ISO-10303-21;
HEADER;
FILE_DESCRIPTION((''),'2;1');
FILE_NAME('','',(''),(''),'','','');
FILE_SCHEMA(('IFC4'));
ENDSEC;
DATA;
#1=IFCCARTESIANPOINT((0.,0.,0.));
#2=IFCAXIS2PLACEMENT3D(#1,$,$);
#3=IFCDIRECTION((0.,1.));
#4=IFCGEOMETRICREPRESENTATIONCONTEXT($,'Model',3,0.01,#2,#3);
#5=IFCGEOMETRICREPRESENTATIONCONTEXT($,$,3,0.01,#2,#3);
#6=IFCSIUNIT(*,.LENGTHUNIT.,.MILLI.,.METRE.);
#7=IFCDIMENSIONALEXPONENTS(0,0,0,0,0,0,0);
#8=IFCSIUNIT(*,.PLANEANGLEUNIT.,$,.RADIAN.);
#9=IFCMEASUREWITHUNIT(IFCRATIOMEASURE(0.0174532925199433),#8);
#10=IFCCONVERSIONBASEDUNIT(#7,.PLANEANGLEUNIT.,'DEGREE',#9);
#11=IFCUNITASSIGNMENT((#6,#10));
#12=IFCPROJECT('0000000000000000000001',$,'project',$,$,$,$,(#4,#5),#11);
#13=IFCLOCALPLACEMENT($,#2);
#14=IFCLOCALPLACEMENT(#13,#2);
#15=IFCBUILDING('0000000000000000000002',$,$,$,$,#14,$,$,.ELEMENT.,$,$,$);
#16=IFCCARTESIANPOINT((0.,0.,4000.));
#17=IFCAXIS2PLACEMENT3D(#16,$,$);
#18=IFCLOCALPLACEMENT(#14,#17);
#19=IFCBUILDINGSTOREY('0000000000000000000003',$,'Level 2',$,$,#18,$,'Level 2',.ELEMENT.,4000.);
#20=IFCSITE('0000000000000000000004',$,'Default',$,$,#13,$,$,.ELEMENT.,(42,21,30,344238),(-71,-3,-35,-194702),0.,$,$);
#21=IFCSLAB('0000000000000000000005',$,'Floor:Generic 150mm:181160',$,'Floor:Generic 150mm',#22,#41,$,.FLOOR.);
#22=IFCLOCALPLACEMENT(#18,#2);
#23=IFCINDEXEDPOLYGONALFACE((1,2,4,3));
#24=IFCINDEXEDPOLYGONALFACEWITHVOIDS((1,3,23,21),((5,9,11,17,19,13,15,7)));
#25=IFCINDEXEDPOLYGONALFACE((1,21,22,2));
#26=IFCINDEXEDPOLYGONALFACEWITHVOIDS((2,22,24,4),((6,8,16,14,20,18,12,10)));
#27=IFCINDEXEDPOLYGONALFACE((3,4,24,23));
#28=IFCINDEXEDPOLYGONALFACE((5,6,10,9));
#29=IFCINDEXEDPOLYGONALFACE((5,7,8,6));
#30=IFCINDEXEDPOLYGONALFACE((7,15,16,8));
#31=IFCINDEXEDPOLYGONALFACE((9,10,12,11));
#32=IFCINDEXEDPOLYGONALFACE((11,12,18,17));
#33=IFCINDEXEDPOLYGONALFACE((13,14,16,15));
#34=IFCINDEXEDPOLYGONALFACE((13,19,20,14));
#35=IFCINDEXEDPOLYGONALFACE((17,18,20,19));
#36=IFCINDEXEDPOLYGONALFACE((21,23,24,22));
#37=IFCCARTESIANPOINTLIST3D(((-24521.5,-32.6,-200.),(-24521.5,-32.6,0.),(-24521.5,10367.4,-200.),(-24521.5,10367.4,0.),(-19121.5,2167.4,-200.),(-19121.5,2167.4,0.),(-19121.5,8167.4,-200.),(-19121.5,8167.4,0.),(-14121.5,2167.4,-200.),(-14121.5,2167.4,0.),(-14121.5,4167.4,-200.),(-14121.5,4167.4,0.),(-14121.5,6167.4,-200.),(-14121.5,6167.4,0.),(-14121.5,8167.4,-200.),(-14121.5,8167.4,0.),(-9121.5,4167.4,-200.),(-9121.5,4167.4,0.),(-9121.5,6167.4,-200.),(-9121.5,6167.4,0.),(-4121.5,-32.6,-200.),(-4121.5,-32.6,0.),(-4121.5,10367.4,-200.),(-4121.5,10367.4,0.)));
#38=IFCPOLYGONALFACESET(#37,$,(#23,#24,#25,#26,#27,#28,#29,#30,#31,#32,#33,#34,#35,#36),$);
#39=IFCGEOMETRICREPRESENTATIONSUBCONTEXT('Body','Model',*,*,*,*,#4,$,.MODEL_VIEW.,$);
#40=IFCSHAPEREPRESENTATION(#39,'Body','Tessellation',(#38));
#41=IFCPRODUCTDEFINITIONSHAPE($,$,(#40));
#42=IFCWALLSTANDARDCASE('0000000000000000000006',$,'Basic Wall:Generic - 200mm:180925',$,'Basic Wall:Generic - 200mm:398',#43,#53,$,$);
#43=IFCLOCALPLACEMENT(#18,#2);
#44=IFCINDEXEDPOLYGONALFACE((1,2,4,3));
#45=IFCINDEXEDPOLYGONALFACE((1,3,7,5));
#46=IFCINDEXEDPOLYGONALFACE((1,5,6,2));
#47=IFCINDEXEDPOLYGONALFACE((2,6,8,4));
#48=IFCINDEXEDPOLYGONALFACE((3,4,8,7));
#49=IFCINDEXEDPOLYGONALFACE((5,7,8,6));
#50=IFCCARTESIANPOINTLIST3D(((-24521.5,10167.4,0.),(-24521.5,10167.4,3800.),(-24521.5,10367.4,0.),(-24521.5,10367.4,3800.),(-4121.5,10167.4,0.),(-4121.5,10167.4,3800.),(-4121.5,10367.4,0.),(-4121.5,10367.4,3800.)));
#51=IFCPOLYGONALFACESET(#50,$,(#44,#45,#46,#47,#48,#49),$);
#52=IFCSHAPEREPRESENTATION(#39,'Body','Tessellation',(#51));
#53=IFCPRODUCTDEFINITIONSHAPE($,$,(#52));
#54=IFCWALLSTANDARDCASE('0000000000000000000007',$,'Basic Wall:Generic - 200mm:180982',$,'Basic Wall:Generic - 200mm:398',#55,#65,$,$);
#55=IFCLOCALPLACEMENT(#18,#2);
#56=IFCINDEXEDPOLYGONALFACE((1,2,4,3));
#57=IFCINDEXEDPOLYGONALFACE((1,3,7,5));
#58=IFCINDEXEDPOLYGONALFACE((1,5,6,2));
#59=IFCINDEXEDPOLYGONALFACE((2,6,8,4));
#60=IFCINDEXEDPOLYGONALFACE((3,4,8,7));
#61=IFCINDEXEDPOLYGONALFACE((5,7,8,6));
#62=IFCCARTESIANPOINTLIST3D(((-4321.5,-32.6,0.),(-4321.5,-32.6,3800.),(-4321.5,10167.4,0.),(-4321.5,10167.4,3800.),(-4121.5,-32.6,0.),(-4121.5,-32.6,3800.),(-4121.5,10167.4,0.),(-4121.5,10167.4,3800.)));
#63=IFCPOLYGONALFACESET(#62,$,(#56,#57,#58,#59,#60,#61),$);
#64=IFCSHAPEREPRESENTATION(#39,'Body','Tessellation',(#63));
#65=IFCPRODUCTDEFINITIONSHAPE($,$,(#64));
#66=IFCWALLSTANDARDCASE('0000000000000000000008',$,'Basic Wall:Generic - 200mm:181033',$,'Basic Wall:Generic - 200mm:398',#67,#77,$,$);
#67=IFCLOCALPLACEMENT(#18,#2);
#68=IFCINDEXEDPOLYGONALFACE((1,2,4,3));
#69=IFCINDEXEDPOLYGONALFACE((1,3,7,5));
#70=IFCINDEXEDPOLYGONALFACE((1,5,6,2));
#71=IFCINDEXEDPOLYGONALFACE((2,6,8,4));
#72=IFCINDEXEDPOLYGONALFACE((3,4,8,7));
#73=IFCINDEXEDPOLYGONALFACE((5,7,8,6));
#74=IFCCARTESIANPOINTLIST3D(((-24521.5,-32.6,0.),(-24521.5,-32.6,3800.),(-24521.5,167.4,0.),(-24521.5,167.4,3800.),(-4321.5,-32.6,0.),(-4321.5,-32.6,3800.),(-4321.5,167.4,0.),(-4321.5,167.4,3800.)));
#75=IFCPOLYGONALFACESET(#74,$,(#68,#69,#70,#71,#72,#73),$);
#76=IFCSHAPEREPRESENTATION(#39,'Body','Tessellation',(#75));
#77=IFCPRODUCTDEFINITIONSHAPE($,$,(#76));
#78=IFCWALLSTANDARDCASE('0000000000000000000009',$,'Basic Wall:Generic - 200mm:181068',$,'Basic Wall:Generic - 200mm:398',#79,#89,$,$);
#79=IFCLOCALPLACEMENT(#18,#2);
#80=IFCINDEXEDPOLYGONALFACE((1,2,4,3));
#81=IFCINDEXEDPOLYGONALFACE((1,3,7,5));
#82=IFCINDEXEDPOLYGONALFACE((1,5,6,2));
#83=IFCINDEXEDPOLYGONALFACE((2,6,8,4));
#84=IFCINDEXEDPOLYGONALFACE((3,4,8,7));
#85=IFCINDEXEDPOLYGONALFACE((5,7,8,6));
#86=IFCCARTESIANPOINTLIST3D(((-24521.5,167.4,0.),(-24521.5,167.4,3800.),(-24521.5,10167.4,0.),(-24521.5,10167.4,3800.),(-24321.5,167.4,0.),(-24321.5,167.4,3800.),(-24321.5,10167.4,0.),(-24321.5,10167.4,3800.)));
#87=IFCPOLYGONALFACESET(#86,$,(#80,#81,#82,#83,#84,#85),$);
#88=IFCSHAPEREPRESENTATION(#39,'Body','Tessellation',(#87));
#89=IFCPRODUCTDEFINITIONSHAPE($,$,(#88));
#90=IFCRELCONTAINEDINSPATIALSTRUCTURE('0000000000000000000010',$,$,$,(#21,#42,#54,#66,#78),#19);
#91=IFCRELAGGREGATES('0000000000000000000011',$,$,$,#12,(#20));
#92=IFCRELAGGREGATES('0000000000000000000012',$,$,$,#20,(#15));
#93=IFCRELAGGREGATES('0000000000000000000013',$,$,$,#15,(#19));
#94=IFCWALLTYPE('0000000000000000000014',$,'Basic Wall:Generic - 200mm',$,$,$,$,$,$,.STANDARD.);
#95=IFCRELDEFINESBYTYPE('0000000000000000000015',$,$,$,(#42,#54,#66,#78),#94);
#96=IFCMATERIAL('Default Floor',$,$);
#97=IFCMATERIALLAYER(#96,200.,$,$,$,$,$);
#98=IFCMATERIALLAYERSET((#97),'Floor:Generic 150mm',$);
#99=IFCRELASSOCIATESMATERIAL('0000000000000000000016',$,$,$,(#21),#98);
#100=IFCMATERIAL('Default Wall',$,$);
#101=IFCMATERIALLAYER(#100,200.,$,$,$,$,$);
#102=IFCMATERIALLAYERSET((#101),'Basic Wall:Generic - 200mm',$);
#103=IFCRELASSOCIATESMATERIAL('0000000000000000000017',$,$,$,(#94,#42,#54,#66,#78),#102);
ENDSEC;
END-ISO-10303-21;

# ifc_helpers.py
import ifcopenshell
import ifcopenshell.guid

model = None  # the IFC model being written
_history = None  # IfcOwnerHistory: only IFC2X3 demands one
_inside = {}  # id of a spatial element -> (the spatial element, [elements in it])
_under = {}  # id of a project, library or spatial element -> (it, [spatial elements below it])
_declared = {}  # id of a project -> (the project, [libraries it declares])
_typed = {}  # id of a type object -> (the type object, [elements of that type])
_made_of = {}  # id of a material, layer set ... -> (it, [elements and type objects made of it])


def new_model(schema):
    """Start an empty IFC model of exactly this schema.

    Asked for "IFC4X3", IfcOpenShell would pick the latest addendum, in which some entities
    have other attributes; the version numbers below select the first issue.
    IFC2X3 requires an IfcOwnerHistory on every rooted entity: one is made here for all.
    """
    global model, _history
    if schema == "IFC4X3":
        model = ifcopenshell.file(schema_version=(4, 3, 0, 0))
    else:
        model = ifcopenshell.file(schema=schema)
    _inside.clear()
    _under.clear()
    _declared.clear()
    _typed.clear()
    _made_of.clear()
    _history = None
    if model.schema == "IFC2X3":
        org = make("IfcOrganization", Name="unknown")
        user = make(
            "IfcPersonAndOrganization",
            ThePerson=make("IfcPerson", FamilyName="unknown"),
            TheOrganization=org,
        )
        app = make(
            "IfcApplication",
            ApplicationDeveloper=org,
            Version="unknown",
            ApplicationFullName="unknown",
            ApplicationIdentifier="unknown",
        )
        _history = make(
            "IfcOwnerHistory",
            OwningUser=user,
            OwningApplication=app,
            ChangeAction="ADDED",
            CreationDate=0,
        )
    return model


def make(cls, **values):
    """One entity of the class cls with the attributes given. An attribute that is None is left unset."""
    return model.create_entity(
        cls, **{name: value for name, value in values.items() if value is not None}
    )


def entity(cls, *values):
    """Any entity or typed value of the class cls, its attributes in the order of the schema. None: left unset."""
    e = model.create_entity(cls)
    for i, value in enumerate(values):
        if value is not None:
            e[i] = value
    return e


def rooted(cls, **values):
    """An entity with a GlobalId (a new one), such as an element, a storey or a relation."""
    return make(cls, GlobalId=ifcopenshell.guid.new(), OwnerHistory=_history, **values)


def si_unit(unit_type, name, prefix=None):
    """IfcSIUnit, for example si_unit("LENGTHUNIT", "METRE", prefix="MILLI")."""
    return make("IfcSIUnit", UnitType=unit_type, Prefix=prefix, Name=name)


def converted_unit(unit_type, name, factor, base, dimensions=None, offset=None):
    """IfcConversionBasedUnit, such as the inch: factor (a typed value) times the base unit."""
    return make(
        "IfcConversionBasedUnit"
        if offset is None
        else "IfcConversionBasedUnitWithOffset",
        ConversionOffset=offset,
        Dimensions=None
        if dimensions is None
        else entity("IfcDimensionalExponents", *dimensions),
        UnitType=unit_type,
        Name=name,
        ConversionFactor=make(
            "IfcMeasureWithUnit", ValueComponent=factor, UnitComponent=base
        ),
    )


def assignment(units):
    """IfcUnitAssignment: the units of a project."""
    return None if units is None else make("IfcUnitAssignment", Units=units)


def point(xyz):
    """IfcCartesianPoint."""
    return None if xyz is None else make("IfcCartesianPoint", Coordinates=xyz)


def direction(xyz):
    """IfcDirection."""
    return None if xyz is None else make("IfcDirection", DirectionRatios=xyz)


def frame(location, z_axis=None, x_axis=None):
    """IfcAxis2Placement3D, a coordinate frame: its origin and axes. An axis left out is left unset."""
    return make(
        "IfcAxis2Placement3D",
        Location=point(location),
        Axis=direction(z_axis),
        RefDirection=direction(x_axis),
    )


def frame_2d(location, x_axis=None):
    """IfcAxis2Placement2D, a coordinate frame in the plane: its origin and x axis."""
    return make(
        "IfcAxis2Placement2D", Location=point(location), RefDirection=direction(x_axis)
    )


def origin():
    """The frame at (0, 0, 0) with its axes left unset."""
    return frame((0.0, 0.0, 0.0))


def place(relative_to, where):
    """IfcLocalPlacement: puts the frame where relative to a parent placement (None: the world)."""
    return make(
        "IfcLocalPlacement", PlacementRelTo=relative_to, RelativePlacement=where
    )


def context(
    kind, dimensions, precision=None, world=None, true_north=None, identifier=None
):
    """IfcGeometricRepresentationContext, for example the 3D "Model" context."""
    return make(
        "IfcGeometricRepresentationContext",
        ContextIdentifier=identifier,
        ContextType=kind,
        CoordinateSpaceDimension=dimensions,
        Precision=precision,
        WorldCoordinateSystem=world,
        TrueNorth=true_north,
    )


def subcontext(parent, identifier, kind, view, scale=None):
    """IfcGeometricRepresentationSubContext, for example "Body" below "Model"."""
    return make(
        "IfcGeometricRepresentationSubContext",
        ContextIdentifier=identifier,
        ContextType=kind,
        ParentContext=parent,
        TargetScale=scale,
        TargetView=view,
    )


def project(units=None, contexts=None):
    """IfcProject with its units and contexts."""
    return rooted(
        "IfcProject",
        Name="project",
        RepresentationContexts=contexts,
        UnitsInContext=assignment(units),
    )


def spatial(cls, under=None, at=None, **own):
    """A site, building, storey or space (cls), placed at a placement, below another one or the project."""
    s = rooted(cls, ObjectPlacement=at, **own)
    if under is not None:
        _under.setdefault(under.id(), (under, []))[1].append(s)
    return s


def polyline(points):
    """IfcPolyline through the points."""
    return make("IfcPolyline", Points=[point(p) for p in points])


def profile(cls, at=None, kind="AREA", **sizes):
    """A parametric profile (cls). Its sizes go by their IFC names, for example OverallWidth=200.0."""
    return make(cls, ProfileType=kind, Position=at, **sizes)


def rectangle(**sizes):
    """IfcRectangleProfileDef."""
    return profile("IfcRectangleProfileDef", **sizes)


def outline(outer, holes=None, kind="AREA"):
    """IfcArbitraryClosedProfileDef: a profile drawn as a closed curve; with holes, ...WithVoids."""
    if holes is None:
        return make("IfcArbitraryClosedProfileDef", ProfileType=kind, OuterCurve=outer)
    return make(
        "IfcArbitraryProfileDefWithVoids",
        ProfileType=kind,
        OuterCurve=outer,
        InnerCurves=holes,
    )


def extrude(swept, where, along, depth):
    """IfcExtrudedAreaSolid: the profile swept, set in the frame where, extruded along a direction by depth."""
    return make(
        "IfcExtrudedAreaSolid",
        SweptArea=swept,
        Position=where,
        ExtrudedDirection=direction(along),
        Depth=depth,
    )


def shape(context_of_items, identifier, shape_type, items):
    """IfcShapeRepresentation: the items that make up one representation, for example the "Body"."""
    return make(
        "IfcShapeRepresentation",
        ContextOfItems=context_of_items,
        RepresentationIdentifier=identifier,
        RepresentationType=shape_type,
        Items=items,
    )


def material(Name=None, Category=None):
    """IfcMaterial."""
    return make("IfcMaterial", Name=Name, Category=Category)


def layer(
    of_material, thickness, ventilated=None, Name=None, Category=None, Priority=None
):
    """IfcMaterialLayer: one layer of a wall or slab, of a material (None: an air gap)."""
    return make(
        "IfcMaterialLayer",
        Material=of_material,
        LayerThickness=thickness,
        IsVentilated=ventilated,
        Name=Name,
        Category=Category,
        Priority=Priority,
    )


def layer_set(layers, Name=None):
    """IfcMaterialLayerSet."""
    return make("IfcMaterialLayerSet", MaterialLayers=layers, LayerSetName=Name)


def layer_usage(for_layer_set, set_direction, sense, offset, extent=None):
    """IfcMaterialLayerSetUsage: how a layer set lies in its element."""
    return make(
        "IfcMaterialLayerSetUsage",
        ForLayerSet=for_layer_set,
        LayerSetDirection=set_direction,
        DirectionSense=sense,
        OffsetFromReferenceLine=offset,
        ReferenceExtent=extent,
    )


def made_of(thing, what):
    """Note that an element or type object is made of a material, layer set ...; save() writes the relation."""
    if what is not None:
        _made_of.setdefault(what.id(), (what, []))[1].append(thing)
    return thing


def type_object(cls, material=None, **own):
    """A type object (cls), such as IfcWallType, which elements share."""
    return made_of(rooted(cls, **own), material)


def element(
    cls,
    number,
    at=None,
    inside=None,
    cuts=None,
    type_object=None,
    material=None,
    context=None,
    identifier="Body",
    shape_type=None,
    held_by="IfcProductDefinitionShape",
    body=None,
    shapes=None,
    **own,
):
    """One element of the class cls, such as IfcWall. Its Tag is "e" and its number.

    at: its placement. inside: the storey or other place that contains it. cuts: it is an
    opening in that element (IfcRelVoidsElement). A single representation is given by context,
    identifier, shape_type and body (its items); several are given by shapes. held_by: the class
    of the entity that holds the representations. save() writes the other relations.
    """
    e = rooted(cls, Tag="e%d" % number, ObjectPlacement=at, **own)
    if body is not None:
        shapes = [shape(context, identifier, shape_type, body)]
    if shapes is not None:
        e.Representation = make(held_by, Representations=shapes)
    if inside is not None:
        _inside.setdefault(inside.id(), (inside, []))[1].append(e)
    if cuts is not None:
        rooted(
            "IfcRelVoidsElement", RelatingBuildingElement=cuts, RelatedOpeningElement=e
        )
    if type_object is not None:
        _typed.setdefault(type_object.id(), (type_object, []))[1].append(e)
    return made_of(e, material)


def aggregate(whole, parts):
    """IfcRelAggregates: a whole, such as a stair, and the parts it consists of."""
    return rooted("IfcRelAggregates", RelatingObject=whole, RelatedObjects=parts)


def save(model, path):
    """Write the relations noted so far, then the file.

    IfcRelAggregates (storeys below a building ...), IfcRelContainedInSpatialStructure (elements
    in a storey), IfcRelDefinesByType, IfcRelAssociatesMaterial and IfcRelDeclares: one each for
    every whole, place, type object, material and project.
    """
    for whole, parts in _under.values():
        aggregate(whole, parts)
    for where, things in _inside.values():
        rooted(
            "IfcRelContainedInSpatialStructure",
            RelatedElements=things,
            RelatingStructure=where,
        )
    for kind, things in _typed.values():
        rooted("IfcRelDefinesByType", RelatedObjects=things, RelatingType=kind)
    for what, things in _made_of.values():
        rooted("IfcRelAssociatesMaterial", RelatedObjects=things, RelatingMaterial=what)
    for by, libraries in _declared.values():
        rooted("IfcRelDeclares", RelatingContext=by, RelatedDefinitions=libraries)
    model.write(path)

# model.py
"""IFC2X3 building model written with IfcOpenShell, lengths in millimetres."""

from ifc_helpers import new_model, entity, si_unit, converted_unit, direction, frame, frame_2d, origin, place, context, subcontext, project, spatial, polyline, rectangle, outline, extrude, material, layer, layer_set, layer_usage, type_object, element, save


model = new_model("IFC2X3")

# Units and contexts
model_context = context("Model", 3, precision=0.01, world=origin(), true_north=direction((0.0, 1.0)))
context_of_model = context(None, 3, precision=0.01, world=origin(), true_north=direction((0.0, 1.0)))
body_context = subcontext(model_context, "Body", "Model", "MODEL_VIEW")
ifc_project = project(units=[si_unit("LENGTHUNIT", "METRE", prefix="MILLI"), converted_unit("PLANEANGLEUNIT", "DEGREE", entity("IfcRatioMeasure", 0.0174532925199433), si_unit("PLANEANGLEUNIT", "RADIAN"), dimensions=[0, 0, 0, 0, 0, 0, 0])], contexts=[model_context, context_of_model])

# Site, building, storey
site_placement = place(None, origin())
site = spatial("IfcSite", under=ifc_project, at=site_placement, Name="Default", CompositionType="ELEMENT", RefLatitude=(42, 21, 30, 344238), RefLongitude=(-71, -3, -35, -194702), RefElevation=0.0)
building_placement = place(site_placement, origin())
building = spatial("IfcBuilding", under=site, at=building_placement, CompositionType="ELEMENT")
storey_placement = place(building_placement, frame((0.0, 0.0, 4000.0)))
storey = spatial("IfcBuildingStorey", under=building, at=storey_placement, Name="Level 2", LongName="Level 2", CompositionType="ELEMENT", Elevation=4000.0)

# Slab, opening
ifc_material_1 = material(Name="Default Floor")
ifc_layer_1 = layer(ifc_material_1, 200.0)
ifc_layer_set_1 = layer_set([ifc_layer_1], Name="Floor:Generic 150mm")
ifc_layer_usage_1 = layer_usage(ifc_layer_set_1, "AXIS3", "POSITIVE", 0.0)
slab_placement = place(storey_placement, frame((-24521.5, -32.6, -200.0)))
slab = element("IfcSlab", 1, at=slab_placement, inside=storey, material=ifc_layer_usage_1, Name="Floor:Generic 150mm:181160", ObjectType="Floor:Generic 150mm", PredefinedType="FLOOR", context=body_context, shape_type="SweptSolid", body=[
    extrude(rectangle(XDim=10400.0, YDim=20400.0, at=frame_2d((0.0, 0.0), x_axis=(0.0, -1.0))), frame((10200.0, 5200.0, 200.0), z_axis=(0.0, 0.0, -1.0), x_axis=(-1.0, 0.0, 0.0)), (0.0, 0.0, 1.0), 200.0),
])
opening_placement = place(slab_placement, frame((10400.0, 5200.0, 200.0)))
element("IfcOpeningElement", 2, at=opening_placement, cuts=slab, ObjectType="Opening", context=body_context, shape_type="SweptSolid", body=[
    extrude(outline(polyline([(-5000.0, 3000.0), (-5000.0, -3000.0), (0.0, -3000.0), (0.0, -1000.0), (5000.0, -1000.0), (5000.0, 1000.0), (0.0, 1000.0), (0.0, 3000.0), (-5000.0, 3000.0)])), origin(), (0.0, 0.0, -1.0), 200.0),
])

# Walls
ifc_material_2 = material(Name="Default Wall")
ifc_layer_2 = layer(ifc_material_2, 200.0)
ifc_layer_set_2 = layer_set([ifc_layer_2], Name="Basic Wall:Generic - 200mm")
ifc_layer_usage_2 = layer_usage(ifc_layer_set_2, "AXIS2", "NEGATIVE", 100.0)
wall_type = type_object("IfcWallType", Name="Basic Wall:Generic - 200mm", PredefinedType="STANDARD", material=ifc_layer_set_2)
wall_1_placement = place(storey_placement, frame((-24521.5, 10267.4, 0.0)))
element("IfcWallStandardCase", 3, at=wall_1_placement, inside=storey, type_object=wall_type, material=ifc_layer_usage_2, Name="Basic Wall:Generic - 200mm:180925", ObjectType="Basic Wall:Generic - 200mm:398", context=body_context, shape_type="SweptSolid", body=[
    extrude(rectangle(XDim=20400.0, YDim=200.0, at=frame_2d((10200.0, 0.0), x_axis=(-1.0, 0.0))), origin(), (0.0, 0.0, 1.0), 3800.0),
])
ifc_layer_usage_3 = layer_usage(ifc_layer_set_2, "AXIS2", "NEGATIVE", 100.0)
wall_2_placement = place(storey_placement, frame((-4221.5, 10167.4, 0.0), z_axis=(0.0, 0.0, 1.0), x_axis=(0.0, -1.0, 0.0)))
element("IfcWallStandardCase", 4, at=wall_2_placement, inside=storey, type_object=wall_type, material=ifc_layer_usage_3, Name="Basic Wall:Generic - 200mm:180982", ObjectType="Basic Wall:Generic - 200mm:398", context=body_context, shape_type="SweptSolid", body=[
    extrude(rectangle(XDim=10200.0, YDim=200.0, at=frame_2d((5100.0, 0.0), x_axis=(-1.0, 0.0))), origin(), (0.0, 0.0, 1.0), 3800.0),
])
ifc_layer_usage_4 = layer_usage(ifc_layer_set_2, "AXIS2", "NEGATIVE", 100.0)
wall_3_placement = place(storey_placement, frame((-4321.5, 67.4, 0.0), z_axis=(0.0, 0.0, 1.0), x_axis=(-1.0, 0.0, 0.0)))
element("IfcWallStandardCase", 5, at=wall_3_placement, inside=storey, type_object=wall_type, material=ifc_layer_usage_4, Name="Basic Wall:Generic - 200mm:181033", ObjectType="Basic Wall:Generic - 200mm:398", context=body_context, shape_type="SweptSolid", body=[
    extrude(rectangle(XDim=20200.0, YDim=200.0, at=frame_2d((10100.0, 0.0), x_axis=(-1.0, 0.0))), origin(), (0.0, 0.0, 1.0), 3800.0),
])
ifc_layer_usage_5 = layer_usage(ifc_layer_set_2, "AXIS2", "NEGATIVE", 100.0)
wall_4_placement = place(storey_placement, frame((-24421.5, 167.4, 0.0), z_axis=(0.0, 0.0, 1.0), x_axis=(0.0, 1.0, 0.0)))
element("IfcWallStandardCase", 6, at=wall_4_placement, inside=storey, type_object=wall_type, material=ifc_layer_usage_5, Name="Basic Wall:Generic - 200mm:181068", ObjectType="Basic Wall:Generic - 200mm:398", context=body_context, shape_type="SweptSolid", body=[
    extrude(rectangle(XDim=10000.0, YDim=200.0, at=frame_2d((5000.0, 0.0), x_axis=(-1.0, 0.0))), origin(), (0.0, 0.0, 1.0), 3800.0),
])

save(model, "model.ifc")
